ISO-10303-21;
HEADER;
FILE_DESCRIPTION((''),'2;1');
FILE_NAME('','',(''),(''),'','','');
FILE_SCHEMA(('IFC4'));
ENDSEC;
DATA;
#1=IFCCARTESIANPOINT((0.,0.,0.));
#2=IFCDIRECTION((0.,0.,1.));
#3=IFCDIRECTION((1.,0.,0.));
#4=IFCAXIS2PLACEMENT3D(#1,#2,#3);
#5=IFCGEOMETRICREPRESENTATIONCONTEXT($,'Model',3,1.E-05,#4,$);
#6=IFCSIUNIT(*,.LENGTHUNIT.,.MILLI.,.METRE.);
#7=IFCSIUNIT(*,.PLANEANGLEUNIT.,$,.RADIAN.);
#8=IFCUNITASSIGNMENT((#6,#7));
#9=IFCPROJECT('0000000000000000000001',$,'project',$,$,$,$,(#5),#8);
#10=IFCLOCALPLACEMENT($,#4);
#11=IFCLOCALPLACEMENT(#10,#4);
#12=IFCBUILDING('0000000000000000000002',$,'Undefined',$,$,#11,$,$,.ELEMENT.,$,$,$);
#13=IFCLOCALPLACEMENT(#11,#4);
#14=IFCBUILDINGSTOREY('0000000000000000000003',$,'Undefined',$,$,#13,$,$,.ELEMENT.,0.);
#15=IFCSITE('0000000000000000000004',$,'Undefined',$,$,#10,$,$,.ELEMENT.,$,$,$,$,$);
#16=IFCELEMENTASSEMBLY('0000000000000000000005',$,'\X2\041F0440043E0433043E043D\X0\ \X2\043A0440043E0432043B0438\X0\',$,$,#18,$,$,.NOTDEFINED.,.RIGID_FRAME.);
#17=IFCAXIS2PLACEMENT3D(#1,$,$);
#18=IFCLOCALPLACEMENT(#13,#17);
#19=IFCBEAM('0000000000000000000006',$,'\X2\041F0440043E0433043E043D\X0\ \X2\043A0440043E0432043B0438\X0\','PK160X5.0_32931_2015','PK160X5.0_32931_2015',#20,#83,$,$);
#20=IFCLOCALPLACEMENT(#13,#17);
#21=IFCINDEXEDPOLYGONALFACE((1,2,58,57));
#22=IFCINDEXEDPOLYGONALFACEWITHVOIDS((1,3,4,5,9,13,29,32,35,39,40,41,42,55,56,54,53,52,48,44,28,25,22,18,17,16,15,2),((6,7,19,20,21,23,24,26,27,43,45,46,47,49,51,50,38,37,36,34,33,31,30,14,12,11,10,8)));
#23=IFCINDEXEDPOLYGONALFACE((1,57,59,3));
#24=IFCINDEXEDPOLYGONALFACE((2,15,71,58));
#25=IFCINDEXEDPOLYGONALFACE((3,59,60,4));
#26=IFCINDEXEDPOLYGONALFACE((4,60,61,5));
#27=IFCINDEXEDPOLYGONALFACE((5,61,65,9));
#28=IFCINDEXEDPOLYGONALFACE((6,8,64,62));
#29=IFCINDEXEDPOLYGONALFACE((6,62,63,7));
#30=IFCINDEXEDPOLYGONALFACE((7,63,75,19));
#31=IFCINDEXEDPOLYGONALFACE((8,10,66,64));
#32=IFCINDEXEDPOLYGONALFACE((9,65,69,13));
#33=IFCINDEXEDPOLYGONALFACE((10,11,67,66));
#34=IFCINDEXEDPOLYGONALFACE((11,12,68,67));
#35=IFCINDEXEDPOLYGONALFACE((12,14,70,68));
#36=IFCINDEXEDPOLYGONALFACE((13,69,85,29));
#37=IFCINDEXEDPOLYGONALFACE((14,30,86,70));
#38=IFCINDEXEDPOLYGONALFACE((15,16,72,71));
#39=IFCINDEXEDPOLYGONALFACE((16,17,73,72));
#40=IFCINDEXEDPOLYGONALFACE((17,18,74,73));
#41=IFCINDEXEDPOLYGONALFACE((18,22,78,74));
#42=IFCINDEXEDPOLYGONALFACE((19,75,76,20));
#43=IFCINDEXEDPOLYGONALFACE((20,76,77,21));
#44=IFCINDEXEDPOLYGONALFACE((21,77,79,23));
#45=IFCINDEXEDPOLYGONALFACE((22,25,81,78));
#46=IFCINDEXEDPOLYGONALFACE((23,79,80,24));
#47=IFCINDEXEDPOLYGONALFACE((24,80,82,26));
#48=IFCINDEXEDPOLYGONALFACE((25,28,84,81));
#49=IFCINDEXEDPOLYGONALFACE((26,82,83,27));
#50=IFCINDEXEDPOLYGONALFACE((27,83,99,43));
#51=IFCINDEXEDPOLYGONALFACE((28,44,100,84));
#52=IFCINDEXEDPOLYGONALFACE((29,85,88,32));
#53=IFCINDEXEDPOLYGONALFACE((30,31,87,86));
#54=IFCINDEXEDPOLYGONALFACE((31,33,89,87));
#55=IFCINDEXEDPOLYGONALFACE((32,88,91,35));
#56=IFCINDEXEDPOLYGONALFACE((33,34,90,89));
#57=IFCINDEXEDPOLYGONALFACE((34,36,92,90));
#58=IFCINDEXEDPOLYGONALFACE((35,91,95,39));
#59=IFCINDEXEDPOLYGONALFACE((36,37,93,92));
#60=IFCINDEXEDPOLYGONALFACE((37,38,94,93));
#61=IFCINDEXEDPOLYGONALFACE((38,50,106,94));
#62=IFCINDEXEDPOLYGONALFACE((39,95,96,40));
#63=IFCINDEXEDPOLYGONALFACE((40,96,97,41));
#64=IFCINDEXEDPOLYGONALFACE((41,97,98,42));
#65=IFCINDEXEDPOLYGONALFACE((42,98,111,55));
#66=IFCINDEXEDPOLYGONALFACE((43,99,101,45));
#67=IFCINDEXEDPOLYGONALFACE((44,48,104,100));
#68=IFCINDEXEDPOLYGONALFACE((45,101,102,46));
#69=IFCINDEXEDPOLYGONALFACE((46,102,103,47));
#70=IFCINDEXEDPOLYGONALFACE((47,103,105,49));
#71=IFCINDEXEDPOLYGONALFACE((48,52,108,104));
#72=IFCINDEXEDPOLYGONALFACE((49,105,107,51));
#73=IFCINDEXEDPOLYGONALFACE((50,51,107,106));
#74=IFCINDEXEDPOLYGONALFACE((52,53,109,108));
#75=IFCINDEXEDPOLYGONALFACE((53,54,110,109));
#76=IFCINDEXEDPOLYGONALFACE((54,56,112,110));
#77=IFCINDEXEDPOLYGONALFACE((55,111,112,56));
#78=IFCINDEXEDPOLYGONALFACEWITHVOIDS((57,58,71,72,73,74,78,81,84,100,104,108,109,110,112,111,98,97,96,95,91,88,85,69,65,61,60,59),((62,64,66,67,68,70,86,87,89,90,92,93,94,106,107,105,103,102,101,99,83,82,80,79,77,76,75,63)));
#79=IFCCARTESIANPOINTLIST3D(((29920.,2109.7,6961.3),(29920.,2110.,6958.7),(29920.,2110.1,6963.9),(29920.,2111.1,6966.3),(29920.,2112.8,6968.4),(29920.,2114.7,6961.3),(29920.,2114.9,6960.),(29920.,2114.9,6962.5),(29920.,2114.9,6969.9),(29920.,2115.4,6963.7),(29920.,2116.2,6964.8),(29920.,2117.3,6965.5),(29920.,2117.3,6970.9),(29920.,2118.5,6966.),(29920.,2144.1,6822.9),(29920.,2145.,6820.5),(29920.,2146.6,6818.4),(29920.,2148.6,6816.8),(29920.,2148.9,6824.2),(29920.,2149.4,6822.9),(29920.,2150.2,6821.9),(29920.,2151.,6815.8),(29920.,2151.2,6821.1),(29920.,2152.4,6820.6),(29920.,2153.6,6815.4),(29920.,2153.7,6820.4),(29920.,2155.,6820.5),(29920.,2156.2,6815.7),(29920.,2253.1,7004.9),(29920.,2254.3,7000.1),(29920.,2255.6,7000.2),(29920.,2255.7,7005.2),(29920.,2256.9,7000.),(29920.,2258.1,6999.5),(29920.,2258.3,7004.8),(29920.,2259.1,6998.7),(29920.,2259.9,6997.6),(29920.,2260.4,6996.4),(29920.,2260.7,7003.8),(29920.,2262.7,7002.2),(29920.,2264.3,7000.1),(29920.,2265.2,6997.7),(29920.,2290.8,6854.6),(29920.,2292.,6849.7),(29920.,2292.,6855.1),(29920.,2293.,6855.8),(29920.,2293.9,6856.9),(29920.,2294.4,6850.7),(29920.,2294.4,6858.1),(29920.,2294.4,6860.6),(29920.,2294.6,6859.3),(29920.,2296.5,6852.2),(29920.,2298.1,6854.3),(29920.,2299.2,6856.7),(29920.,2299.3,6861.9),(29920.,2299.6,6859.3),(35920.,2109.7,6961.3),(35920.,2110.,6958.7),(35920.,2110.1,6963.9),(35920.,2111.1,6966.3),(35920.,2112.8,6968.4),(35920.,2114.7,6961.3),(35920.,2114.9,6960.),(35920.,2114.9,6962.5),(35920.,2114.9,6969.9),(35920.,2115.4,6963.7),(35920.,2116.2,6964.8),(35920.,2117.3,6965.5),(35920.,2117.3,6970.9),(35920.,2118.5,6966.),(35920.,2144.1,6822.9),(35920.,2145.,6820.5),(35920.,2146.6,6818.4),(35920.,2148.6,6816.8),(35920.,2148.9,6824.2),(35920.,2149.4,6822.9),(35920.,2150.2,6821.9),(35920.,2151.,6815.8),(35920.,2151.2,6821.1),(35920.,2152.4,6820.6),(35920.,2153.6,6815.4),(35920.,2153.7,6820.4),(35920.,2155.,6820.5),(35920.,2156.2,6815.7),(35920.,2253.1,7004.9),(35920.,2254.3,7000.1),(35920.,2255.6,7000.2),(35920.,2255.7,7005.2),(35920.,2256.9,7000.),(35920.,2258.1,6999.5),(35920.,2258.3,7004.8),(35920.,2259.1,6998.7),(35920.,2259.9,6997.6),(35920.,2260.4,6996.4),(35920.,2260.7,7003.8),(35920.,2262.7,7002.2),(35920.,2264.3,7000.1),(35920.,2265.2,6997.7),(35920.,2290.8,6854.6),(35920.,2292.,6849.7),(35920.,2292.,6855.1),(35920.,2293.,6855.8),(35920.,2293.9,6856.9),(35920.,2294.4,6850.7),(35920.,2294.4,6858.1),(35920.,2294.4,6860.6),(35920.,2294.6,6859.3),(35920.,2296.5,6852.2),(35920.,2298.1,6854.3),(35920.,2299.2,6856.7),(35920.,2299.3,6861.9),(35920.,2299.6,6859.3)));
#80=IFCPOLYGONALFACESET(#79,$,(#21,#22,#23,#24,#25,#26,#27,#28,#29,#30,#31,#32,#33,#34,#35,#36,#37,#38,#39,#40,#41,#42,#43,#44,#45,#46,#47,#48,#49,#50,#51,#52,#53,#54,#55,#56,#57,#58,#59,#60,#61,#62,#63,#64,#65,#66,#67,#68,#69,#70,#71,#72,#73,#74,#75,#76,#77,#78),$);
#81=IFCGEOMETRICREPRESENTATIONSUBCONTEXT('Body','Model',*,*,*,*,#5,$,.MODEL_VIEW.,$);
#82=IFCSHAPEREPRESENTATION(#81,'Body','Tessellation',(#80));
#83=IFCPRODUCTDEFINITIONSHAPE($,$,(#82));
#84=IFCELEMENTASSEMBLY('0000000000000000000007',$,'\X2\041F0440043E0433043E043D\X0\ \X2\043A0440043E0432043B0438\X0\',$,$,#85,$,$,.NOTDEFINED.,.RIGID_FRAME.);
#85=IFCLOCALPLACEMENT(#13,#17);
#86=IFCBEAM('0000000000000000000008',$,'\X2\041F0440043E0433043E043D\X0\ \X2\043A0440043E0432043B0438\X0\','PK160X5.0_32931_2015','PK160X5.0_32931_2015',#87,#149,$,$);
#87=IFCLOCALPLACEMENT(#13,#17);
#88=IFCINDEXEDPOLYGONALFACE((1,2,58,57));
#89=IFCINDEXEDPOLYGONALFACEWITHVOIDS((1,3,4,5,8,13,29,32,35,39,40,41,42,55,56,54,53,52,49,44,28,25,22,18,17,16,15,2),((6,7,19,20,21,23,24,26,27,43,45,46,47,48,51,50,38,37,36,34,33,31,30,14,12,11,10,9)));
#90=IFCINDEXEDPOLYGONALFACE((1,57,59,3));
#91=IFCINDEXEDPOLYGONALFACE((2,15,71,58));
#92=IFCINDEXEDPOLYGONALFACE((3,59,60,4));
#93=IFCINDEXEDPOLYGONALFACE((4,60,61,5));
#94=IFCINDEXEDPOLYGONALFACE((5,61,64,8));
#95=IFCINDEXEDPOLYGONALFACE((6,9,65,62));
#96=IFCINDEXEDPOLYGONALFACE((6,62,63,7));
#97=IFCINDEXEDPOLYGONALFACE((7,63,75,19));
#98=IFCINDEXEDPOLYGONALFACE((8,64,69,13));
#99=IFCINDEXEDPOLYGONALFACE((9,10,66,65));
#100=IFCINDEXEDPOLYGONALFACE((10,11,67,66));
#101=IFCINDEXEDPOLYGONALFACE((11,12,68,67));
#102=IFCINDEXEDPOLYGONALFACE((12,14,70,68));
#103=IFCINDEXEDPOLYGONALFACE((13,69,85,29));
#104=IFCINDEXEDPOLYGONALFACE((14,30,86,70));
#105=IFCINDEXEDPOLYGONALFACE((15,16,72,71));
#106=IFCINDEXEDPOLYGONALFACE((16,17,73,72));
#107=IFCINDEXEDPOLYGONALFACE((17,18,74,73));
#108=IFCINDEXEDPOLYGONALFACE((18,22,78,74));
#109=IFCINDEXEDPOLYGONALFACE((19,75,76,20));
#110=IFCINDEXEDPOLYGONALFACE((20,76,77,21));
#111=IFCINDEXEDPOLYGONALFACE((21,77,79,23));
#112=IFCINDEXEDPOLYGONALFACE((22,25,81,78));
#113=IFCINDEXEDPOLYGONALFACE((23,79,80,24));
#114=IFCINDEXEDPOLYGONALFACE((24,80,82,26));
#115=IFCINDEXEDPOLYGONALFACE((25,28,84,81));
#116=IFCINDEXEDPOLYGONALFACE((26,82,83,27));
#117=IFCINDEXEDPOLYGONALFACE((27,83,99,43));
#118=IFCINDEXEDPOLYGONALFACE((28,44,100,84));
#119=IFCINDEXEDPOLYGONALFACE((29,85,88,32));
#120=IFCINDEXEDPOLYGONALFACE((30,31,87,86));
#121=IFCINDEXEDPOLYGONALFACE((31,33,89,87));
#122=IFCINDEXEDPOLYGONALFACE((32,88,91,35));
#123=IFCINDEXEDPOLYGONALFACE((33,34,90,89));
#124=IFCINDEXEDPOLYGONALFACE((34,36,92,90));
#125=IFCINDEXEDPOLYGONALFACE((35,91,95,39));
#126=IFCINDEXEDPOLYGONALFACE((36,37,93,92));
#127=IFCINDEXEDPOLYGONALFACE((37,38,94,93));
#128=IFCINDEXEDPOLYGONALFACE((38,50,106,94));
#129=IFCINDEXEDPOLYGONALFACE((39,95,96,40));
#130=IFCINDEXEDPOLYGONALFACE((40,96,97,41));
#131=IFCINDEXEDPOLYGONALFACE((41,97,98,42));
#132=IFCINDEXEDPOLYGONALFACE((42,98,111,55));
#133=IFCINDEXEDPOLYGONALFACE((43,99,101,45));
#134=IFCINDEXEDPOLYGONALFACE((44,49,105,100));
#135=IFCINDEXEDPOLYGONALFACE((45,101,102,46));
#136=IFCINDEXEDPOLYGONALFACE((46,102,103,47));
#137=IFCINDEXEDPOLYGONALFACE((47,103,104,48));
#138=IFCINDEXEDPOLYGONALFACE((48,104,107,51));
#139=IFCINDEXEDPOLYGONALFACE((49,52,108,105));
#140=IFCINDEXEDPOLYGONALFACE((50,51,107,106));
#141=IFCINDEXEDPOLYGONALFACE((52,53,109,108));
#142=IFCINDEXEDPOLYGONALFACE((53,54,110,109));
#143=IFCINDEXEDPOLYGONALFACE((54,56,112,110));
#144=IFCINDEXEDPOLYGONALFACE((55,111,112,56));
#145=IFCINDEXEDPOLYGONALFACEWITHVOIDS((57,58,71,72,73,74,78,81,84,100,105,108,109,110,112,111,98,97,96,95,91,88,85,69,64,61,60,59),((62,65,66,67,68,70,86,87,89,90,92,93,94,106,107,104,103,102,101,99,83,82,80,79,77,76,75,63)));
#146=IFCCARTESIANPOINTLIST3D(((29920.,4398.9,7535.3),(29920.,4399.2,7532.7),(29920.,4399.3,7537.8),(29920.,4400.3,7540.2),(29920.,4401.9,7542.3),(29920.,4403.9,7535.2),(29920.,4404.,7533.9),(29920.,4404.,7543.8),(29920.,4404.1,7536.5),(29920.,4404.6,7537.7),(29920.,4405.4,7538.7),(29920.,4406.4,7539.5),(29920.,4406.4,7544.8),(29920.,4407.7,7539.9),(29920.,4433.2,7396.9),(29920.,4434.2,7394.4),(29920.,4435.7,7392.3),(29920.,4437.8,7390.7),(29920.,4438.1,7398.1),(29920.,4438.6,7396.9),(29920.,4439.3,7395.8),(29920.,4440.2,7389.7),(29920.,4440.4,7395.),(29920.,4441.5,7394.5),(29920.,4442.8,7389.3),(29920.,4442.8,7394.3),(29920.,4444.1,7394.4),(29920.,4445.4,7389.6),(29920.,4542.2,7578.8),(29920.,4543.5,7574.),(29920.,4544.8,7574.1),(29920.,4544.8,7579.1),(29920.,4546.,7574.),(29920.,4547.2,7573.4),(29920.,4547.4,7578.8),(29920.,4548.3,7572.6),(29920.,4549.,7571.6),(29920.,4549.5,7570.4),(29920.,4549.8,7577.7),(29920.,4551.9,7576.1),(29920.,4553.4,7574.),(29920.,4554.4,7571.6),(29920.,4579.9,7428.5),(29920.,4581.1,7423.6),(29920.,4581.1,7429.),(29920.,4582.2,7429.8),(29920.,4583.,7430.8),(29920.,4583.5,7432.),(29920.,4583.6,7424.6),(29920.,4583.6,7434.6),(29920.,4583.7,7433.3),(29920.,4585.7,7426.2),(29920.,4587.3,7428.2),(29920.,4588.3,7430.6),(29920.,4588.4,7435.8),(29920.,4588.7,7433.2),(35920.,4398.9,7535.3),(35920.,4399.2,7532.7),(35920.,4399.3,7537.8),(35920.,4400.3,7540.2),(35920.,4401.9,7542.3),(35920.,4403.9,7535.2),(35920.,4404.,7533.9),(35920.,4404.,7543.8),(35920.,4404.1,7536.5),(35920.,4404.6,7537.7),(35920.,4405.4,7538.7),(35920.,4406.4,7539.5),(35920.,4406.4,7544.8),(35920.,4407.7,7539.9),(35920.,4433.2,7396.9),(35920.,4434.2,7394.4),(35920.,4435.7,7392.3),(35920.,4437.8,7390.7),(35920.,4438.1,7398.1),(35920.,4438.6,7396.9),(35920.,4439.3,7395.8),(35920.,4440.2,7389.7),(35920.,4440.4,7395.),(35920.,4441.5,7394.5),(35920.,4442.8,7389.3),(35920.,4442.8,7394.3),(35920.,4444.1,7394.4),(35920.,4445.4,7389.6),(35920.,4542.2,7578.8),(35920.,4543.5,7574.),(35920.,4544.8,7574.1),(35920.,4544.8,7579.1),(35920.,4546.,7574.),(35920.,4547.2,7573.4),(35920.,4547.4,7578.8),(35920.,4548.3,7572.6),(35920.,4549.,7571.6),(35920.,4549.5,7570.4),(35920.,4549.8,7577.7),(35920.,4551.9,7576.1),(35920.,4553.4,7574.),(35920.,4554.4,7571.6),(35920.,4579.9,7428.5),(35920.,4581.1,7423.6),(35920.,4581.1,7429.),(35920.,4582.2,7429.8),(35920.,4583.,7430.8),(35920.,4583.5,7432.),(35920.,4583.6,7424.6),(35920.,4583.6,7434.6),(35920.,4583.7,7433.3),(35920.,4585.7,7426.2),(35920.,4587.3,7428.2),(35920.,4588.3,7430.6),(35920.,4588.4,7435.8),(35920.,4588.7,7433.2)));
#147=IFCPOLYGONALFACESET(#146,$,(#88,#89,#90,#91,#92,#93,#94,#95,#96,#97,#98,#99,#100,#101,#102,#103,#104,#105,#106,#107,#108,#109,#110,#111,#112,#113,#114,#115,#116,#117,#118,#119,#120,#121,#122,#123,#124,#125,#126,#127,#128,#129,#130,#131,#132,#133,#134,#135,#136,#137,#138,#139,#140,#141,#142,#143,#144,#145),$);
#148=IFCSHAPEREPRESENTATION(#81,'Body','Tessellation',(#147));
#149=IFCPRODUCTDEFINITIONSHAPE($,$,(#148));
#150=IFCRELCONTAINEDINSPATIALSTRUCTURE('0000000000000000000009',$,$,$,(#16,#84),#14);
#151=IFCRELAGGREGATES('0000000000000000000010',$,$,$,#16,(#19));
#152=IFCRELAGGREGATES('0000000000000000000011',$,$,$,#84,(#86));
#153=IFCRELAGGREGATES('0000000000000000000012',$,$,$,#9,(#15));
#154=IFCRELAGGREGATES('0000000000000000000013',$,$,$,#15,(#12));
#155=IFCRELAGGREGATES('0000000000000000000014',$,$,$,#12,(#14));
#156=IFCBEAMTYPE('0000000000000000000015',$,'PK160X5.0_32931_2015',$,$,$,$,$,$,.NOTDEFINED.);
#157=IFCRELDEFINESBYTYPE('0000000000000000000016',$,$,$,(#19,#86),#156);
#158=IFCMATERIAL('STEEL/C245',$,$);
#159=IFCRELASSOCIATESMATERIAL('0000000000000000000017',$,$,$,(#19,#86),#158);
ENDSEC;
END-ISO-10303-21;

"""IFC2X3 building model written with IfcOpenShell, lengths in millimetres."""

from ifc_helpers import new_model, si_unit, frame, origin_with_axes, origin_2d_with_axis, place, context, subcontext, project, spatial, hollow_rectangle, extrude, material, type_object, element, aggregate, save


model = new_model("IFC2X3")

# Units and contexts
model_context = context("Model", 3, precision=1e-05, world=origin_with_axes())
body_context = subcontext(model_context, "Body", "Model", "MODEL_VIEW")
ifc_project = project(units=[si_unit("LENGTHUNIT", "METRE", prefix="MILLI"), si_unit("PLANEANGLEUNIT", "RADIAN")], contexts=[model_context])

# Site, building, storey
site_placement = place(None, origin_with_axes())
site = spatial("IfcSite", under=ifc_project, at=site_placement, Name="Undefined", CompositionType="ELEMENT")
building_placement = place(site_placement, origin_with_axes())
building = spatial("IfcBuilding", under=site, at=building_placement, Name="Undefined", CompositionType="ELEMENT")
storey_placement = place(building_placement, origin_with_axes())
storey = spatial("IfcBuildingStorey", under=building, at=storey_placement, Name="Undefined", CompositionType="ELEMENT", Elevation=0.0)

# Shared definitions
ifc_material = material(Name="STEEL/C245")

# Element assemblies, beams
assembly_1_placement = place(storey_placement, origin_with_axes())
assembly_1 = element("IfcElementAssembly", 1, at=assembly_1_placement, inside=storey, Name="Прогон кровли", AssemblyPlace="NOTDEFINED", PredefinedType="RIGID_FRAME")
beam_type_1 = type_object("IfcBeamType", Name="PK160X5.0_32931_2015", PredefinedType="NOTDEFINED")
beam_1_placement = place(assembly_1_placement, frame((29920.0, 2204.6, 6910.3), z_axis=(0.0, -0.243188, 0.969979), x_axis=(1.0, 0.0, 0.0)))
beam_1 = element("IfcBeam", 2, at=beam_1_placement, type_object=beam_type_1, material=ifc_material, Name="Прогон кровли", Description="PK160X5.0_32931_2015", ObjectType="PK160X5.0_32931_2015", context=body_context, shape_type="SweptSolid", body=[
    extrude(hollow_rectangle(XDim=160.0, YDim=160.0, WallThickness=5.0, InnerFilletRadius=5.0, OuterFilletRadius=10.0, at=origin_2d_with_axis()), frame((6000.0, 0.0, 0.0), z_axis=(-1.0, 0.0, 0.0), x_axis=(0.0, -1.0, 0.0)), (0.0, 0.0, 1.0), 6000.0),
])
aggregate(assembly_1, [beam_1])
assembly_2_placement = place(storey_placement, origin_with_axes())
assembly_2 = element("IfcElementAssembly", 3, at=assembly_2_placement, inside=storey, Name="Прогон кровли", AssemblyPlace="NOTDEFINED", PredefinedType="RIGID_FRAME")
beam_2_placement = place(assembly_2_placement, frame((29920.0, 4493.8, 7484.2), z_axis=(0.0, -0.243188, 0.969979), x_axis=(1.0, 0.0, 0.0)))
beam_2 = element("IfcBeam", 4, at=beam_2_placement, type_object=beam_type_1, material=ifc_material, Name="Прогон кровли", Description="PK160X5.0_32931_2015", ObjectType="PK160X5.0_32931_2015", context=body_context, shape_type="SweptSolid", body=[
    extrude(hollow_rectangle(XDim=160.0, YDim=160.0, WallThickness=5.0, InnerFilletRadius=5.0, OuterFilletRadius=10.0, at=origin_2d_with_axis()), frame((6000.0, 0.0, 0.0), z_axis=(-1.0, 0.0, 0.0), x_axis=(0.0, -1.0, 0.0)), (0.0, 0.0, 1.0), 6000.0),
])
aggregate(assembly_2, [beam_2])

save(model, "model.ifc")
